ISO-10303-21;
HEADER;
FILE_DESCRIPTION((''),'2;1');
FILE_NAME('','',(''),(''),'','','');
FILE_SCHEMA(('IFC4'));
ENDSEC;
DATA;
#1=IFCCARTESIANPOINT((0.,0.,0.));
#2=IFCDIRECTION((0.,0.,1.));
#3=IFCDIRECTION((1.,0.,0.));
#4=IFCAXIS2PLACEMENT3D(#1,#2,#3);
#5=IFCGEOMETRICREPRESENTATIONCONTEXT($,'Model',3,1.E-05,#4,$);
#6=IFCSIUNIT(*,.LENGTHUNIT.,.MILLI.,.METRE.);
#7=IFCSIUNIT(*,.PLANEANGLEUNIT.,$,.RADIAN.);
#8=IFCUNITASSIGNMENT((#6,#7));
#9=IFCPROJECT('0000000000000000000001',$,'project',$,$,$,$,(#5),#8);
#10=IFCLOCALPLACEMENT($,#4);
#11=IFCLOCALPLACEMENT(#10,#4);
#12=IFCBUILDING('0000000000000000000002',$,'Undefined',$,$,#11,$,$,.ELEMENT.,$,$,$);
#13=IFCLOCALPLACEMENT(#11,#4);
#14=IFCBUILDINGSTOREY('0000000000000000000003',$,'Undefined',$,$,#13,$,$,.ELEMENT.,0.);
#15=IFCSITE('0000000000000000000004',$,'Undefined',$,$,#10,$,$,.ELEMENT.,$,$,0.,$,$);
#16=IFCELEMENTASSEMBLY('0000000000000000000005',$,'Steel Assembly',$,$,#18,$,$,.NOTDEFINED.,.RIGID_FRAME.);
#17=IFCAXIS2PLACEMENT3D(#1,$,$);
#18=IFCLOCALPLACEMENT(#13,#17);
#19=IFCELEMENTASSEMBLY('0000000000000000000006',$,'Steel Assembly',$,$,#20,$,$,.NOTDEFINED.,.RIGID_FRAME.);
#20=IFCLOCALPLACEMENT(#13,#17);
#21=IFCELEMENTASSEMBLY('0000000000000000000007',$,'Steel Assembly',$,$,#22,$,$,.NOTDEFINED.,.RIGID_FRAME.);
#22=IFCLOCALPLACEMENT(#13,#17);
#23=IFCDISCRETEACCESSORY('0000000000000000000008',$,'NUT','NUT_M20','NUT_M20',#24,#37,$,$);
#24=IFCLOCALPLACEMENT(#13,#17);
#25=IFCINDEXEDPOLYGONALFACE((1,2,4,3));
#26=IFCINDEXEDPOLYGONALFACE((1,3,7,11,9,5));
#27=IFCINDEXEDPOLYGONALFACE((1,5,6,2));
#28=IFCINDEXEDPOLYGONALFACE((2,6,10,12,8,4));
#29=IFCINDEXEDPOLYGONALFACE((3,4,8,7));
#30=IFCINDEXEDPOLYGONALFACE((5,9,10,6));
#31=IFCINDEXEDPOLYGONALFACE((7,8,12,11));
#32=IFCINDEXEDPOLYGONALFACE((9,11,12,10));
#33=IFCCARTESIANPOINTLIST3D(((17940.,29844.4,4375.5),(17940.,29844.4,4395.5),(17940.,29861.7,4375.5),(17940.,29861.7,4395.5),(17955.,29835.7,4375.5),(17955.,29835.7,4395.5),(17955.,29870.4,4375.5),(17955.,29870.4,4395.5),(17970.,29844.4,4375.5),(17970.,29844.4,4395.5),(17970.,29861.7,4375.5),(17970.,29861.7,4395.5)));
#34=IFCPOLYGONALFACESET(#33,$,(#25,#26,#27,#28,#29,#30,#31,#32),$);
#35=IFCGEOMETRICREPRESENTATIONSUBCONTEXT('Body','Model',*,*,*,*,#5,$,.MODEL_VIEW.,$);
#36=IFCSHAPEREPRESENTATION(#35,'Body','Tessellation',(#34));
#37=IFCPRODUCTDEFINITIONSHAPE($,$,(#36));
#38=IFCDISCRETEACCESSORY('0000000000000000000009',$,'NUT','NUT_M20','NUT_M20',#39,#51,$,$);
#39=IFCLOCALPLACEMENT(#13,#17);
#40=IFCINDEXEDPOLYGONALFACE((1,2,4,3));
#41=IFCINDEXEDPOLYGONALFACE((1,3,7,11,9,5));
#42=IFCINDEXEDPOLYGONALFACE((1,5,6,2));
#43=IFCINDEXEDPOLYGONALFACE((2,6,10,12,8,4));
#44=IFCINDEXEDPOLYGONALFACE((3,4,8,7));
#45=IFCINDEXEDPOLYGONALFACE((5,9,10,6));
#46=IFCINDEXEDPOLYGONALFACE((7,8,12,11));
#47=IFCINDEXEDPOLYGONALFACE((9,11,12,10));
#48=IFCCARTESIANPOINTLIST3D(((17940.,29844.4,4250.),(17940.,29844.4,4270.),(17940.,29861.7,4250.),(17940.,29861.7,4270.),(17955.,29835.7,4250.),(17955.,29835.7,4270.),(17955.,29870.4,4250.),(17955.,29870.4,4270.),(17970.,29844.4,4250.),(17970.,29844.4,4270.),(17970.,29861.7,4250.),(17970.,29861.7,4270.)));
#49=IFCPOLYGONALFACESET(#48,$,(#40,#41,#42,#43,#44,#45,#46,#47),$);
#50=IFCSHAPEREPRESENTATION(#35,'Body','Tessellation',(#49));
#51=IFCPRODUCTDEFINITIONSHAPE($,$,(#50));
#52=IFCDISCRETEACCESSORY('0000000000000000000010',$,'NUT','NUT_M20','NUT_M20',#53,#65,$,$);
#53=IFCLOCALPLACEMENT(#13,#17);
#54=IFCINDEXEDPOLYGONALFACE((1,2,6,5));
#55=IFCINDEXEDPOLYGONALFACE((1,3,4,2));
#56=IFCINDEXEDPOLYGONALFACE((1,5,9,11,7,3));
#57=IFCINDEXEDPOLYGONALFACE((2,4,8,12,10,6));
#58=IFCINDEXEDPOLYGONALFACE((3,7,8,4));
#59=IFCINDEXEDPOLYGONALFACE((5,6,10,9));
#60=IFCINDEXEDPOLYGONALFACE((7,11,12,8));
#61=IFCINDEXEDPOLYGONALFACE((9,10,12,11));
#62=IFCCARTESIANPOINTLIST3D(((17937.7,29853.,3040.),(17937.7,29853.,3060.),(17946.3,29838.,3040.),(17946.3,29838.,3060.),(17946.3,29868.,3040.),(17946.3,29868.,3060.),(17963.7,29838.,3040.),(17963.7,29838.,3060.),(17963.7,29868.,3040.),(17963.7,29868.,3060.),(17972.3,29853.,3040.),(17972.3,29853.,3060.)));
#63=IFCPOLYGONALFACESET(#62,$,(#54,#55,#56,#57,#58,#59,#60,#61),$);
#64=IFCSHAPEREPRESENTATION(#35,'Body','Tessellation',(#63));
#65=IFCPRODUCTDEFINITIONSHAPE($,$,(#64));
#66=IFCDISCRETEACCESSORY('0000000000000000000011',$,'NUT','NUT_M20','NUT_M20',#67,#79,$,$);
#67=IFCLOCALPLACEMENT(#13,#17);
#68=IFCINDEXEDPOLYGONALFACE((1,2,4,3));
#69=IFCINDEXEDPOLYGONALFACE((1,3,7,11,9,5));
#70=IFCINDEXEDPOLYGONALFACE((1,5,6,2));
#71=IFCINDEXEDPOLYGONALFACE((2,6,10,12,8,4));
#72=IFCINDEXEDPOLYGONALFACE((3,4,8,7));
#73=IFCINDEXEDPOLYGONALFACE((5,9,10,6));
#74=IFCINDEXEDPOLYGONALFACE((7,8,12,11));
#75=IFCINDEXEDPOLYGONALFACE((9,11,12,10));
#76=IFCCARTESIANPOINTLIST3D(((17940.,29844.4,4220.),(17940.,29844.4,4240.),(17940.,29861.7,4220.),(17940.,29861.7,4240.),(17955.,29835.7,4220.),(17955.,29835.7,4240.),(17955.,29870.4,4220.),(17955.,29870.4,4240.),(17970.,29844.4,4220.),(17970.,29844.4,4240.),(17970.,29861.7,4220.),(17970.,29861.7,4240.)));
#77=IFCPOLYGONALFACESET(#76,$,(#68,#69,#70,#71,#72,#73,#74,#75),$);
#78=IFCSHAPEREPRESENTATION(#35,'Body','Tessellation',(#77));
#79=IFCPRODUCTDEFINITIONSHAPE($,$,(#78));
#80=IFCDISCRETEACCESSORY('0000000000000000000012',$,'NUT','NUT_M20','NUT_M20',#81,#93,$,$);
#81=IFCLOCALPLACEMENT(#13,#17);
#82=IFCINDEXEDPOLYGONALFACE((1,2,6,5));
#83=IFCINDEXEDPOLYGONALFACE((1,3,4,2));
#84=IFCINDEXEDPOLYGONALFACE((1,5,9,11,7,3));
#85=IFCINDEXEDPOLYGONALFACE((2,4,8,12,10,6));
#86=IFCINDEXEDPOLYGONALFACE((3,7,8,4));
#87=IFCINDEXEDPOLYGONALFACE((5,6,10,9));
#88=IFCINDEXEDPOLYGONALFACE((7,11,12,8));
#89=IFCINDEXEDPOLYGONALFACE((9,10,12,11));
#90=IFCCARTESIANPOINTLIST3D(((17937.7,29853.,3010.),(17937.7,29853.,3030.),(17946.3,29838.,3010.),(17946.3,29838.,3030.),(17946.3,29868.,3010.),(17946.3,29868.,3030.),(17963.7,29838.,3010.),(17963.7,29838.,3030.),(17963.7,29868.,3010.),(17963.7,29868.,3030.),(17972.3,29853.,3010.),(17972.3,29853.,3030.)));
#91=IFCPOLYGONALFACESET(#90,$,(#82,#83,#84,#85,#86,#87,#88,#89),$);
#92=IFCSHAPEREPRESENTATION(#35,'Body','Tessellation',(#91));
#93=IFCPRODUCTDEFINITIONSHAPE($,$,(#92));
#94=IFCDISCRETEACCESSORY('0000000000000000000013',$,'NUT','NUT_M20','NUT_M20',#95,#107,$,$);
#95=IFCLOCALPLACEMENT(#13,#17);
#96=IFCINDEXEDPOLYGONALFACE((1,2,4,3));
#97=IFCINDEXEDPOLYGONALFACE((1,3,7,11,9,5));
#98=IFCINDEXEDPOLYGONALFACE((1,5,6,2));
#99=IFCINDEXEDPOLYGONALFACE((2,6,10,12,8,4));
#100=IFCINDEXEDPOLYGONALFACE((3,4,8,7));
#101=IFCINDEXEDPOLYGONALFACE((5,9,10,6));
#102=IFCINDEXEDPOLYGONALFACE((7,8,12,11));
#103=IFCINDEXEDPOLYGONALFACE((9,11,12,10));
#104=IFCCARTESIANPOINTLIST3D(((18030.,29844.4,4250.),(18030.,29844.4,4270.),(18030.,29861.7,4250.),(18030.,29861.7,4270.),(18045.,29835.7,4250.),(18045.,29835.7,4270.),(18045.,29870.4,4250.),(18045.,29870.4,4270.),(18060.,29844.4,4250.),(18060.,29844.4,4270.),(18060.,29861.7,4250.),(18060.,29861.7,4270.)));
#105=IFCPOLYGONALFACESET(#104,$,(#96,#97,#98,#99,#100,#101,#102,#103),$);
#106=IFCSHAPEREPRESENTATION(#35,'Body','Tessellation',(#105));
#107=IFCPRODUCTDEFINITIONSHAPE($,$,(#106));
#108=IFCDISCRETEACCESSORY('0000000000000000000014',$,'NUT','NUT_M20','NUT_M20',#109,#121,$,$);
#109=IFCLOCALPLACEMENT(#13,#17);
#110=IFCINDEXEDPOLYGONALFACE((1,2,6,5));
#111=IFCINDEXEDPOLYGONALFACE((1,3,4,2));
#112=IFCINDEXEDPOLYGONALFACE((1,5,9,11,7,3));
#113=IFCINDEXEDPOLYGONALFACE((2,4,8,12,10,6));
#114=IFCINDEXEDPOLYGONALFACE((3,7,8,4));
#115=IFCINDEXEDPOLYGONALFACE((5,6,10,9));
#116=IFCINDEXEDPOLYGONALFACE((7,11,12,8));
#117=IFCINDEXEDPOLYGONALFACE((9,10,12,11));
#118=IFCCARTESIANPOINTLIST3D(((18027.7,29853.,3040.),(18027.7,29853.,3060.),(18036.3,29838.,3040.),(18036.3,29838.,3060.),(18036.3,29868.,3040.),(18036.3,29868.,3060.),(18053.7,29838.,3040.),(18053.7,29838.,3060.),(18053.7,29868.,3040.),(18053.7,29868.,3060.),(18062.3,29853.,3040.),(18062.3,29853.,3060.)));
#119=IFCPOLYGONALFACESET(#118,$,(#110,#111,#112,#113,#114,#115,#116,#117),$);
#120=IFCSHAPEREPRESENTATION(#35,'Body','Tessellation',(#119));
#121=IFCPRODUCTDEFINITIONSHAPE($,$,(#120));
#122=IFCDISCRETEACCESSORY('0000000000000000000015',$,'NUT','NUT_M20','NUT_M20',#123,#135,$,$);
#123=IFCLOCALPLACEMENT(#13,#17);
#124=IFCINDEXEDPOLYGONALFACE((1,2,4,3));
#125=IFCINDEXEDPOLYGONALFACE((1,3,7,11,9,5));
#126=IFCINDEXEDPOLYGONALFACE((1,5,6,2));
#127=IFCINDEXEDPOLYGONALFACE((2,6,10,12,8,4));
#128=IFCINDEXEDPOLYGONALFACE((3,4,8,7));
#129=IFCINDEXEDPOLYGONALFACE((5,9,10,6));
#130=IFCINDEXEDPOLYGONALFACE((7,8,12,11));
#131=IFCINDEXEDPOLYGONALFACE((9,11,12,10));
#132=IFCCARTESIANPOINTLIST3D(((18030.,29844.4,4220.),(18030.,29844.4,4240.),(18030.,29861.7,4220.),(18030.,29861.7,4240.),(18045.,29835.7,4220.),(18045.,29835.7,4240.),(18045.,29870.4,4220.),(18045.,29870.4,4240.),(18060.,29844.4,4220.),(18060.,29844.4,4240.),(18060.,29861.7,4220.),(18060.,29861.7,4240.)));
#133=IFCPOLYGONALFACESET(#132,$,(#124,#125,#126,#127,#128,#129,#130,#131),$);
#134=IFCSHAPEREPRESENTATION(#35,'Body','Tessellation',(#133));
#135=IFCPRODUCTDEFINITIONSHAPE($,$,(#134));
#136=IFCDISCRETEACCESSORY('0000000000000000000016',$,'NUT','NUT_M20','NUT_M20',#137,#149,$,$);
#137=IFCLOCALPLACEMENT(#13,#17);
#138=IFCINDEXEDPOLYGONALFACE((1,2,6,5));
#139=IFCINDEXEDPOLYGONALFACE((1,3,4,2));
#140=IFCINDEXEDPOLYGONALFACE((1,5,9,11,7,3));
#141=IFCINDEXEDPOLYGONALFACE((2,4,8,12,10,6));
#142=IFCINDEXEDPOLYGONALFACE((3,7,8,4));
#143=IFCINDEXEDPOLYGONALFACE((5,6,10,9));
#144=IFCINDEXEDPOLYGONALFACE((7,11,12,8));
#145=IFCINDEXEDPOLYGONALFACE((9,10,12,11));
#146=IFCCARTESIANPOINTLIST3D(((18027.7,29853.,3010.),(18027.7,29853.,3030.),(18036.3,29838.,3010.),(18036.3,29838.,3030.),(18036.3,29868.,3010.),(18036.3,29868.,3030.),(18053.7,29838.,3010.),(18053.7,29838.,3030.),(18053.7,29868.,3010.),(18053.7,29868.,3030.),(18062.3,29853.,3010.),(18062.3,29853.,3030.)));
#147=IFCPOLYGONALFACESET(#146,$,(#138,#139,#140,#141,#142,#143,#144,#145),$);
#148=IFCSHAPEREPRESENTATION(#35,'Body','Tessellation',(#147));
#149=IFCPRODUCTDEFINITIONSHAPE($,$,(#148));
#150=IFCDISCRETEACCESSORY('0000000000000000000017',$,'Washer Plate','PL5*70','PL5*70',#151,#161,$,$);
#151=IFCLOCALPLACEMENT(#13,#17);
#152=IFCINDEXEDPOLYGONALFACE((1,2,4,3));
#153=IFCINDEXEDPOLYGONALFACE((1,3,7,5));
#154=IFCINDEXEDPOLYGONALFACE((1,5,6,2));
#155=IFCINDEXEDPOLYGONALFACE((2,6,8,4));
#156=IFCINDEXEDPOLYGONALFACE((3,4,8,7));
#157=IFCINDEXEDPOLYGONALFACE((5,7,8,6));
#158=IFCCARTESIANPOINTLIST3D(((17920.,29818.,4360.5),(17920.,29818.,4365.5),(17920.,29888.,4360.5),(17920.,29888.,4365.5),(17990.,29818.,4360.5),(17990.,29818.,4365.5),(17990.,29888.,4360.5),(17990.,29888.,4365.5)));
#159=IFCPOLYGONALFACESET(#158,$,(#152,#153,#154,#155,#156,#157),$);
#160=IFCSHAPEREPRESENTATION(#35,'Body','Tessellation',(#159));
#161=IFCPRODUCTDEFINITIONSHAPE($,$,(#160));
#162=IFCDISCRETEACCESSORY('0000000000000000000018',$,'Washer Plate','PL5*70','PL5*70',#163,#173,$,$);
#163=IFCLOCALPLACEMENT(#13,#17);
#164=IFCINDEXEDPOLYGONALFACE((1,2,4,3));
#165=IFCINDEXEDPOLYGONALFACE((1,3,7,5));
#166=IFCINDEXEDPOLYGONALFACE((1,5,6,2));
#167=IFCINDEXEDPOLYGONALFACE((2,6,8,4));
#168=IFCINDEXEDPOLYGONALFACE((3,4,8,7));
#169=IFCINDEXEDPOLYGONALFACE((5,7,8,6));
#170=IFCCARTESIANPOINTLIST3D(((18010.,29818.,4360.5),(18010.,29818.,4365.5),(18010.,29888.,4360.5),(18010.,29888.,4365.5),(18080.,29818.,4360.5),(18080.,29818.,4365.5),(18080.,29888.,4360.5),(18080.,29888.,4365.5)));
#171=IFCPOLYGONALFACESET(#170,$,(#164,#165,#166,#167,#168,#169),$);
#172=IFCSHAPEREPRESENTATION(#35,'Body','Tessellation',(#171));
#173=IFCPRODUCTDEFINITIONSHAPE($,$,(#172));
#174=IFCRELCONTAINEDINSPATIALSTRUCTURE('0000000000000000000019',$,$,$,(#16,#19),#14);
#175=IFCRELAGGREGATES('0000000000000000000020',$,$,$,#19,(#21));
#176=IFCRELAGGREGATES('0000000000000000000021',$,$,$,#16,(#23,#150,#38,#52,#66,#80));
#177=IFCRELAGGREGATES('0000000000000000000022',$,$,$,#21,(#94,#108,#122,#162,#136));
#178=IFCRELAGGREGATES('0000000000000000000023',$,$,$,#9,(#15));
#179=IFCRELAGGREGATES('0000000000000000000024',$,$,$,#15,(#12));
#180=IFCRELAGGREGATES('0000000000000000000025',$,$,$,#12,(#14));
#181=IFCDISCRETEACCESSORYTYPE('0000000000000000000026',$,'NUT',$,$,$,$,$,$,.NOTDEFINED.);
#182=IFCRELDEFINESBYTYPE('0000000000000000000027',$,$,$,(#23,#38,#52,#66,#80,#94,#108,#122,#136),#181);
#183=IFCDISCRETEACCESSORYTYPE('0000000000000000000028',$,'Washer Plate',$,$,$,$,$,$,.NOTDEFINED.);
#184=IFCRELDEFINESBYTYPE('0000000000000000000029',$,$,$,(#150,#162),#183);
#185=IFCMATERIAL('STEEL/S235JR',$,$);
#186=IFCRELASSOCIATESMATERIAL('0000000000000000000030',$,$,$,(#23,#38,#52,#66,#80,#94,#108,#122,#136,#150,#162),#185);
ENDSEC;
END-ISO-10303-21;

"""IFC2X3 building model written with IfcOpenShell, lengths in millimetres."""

from ifc_helpers import new_model, si_unit, frame, origin_with_axes, place, context, subcontext, project, spatial, polyline, outline, extrude, material, type_object, element, aggregate, save


model = new_model("IFC2X3")

# Units and contexts
model_context = context("Model", 3, precision=1e-05, world=origin_with_axes())
body_context = subcontext(model_context, "Body", "Model", "MODEL_VIEW")
ifc_project = project(units=[si_unit("LENGTHUNIT", "METRE", prefix="MILLI"), si_unit("PLANEANGLEUNIT", "RADIAN")], contexts=[model_context])

# Site, building, storey
site_placement = place(None, origin_with_axes())
site = spatial("IfcSite", under=ifc_project, at=site_placement, Name="Undefined", CompositionType="ELEMENT", RefElevation=0.0)
building_placement = place(site_placement, origin_with_axes())
building = spatial("IfcBuilding", under=site, at=building_placement, Name="Undefined", CompositionType="ELEMENT")
storey_placement = place(building_placement, origin_with_axes())
storey = spatial("IfcBuildingStorey", under=building, at=storey_placement, Name="Undefined", CompositionType="ELEMENT", Elevation=0.0)

# Element assembly
assembly_1_placement = place(storey_placement, origin_with_axes())
assembly_1 = element("IfcElementAssembly", 1, at=assembly_1_placement, inside=storey, Name="Steel Assembly", AssemblyPlace="NOTDEFINED", PredefinedType="RIGID_FRAME")

# Element assemblies
assembly_2_placement = place(storey_placement, origin_with_axes())
assembly_2 = element("IfcElementAssembly", 2, at=assembly_2_placement, inside=storey, Name="Steel Assembly", AssemblyPlace="NOTDEFINED", PredefinedType="RIGID_FRAME")
assembly_3_placement = place(assembly_2_placement, origin_with_axes())
assembly_3 = element("IfcElementAssembly", 3, at=assembly_3_placement, Name="Steel Assembly", AssemblyPlace="NOTDEFINED", PredefinedType="RIGID_FRAME")

# Shared definitions
ifc_material_1 = material(Name="STEEL/S235JR")

aggregate(assembly_2, [assembly_3])

# Discrete accessories
discrete_accessory_type_1 = type_object("IfcDiscreteAccessoryType", Name="NUT")
discrete_accessory_1_placement = place(assembly_1_placement, frame((17955.0, 29853.0, 4395.5), z_axis=(-1.0, 0.0, 0.0), x_axis=(0.0, 0.0, -1.0)))
discrete_accessory_1 = element("IfcDiscreteAccessory", 4, at=discrete_accessory_1_placement, type_object=discrete_accessory_type_1, material=ifc_material_1, Name="NUT", Description="NUT_M20", ObjectType="NUT_M20", context=body_context, shape_type="SweptSolid", body=[
    extrude(outline(polyline([(8.7, 15.0), (17.3, 0.0), (8.7, -15.0), (-8.7, -15.0), (-17.3, 0.0), (-8.7, 15.0), (8.7, 15.0)])), frame((20.0, 0.0, 0.0), z_axis=(-1.0, 0.0, 0.0), x_axis=(0.0, -1.0, 0.0)), (0.0, 0.0, 1.0), 20.0),
])
discrete_accessory_2_placement = place(assembly_1_placement, frame((17955.0, 29853.0, 4270.0), z_axis=(-1.0, 0.0, 0.0), x_axis=(0.0, 0.0, -1.0)))
discrete_accessory_2 = element("IfcDiscreteAccessory", 5, at=discrete_accessory_2_placement, type_object=discrete_accessory_type_1, material=ifc_material_1, Name="NUT", Description="NUT_M20", ObjectType="NUT_M20", context=body_context, shape_type="SweptSolid", body=[
    extrude(outline(polyline([(8.7, 15.0), (17.3, 0.0), (8.7, -15.0), (-8.7, -15.0), (-17.3, 0.0), (-8.7, 15.0), (8.7, 15.0)])), frame((20.0, 0.0, 0.0), z_axis=(-1.0, 0.0, 0.0), x_axis=(0.0, -1.0, 0.0)), (0.0, 0.0, 1.0), 20.0),
])
discrete_accessory_3_placement = place(assembly_1_placement, frame((17955.0, 29853.0, 3060.0), z_axis=(0.0, -1.0, 0.0), x_axis=(0.0, 0.0, -1.0)))
discrete_accessory_3 = element("IfcDiscreteAccessory", 6, at=discrete_accessory_3_placement, type_object=discrete_accessory_type_1, material=ifc_material_1, Name="NUT", Description="NUT_M20", ObjectType="NUT_M20", context=body_context, shape_type="SweptSolid", body=[
    extrude(outline(polyline([(8.7, 15.0), (17.3, 0.0), (8.7, -15.0), (-8.7, -15.0), (-17.3, 0.0), (-8.7, 15.0), (8.7, 15.0)])), frame((20.0, 0.0, 0.0), z_axis=(-1.0, 0.0, 0.0), x_axis=(0.0, -1.0, 0.0)), (0.0, 0.0, 1.0), 20.0),
])
discrete_accessory_4_placement = place(assembly_1_placement, frame((17955.0, 29853.0, 4240.0), z_axis=(-1.0, 0.0, 0.0), x_axis=(0.0, 0.0, -1.0)))
discrete_accessory_4 = element("IfcDiscreteAccessory", 7, at=discrete_accessory_4_placement, type_object=discrete_accessory_type_1, material=ifc_material_1, Name="NUT", Description="NUT_M20", ObjectType="NUT_M20", context=body_context, shape_type="SweptSolid", body=[
    extrude(outline(polyline([(8.7, 15.0), (17.3, 0.0), (8.7, -15.0), (-8.7, -15.0), (-17.3, 0.0), (-8.7, 15.0), (8.7, 15.0)])), frame((20.0, 0.0, 0.0), z_axis=(-1.0, 0.0, 0.0), x_axis=(0.0, -1.0, 0.0)), (0.0, 0.0, 1.0), 20.0),
])
discrete_accessory_5_placement = place(assembly_1_placement, frame((17955.0, 29853.0, 3030.0), z_axis=(0.0, -1.0, 0.0), x_axis=(0.0, 0.0, -1.0)))
discrete_accessory_5 = element("IfcDiscreteAccessory", 8, at=discrete_accessory_5_placement, type_object=discrete_accessory_type_1, material=ifc_material_1, Name="NUT", Description="NUT_M20", ObjectType="NUT_M20", context=body_context, shape_type="SweptSolid", body=[
    extrude(outline(polyline([(8.7, 15.0), (17.3, 0.0), (8.7, -15.0), (-8.7, -15.0), (-17.3, 0.0), (-8.7, 15.0), (8.7, 15.0)])), frame((20.0, 0.0, 0.0), z_axis=(-1.0, 0.0, 0.0), x_axis=(0.0, -1.0, 0.0)), (0.0, 0.0, 1.0), 20.0),
])
discrete_accessory_6_placement = place(assembly_3_placement, frame((18045.0, 29853.0, 4270.0), z_axis=(-1.0, 0.0, 0.0), x_axis=(0.0, 0.0, -1.0)))
discrete_accessory_6 = element("IfcDiscreteAccessory", 9, at=discrete_accessory_6_placement, type_object=discrete_accessory_type_1, material=ifc_material_1, Name="NUT", Description="NUT_M20", ObjectType="NUT_M20", context=body_context, shape_type="SweptSolid", body=[
    extrude(outline(polyline([(8.7, 15.0), (17.3, 0.0), (8.7, -15.0), (-8.7, -15.0), (-17.3, 0.0), (-8.7, 15.0), (8.7, 15.0)])), frame((20.0, 0.0, 0.0), z_axis=(-1.0, 0.0, 0.0), x_axis=(0.0, -1.0, 0.0)), (0.0, 0.0, 1.0), 20.0),
])
discrete_accessory_7_placement = place(assembly_3_placement, frame((18045.0, 29853.0, 3060.0), z_axis=(0.0, -1.0, 0.0), x_axis=(0.0, 0.0, -1.0)))
discrete_accessory_7 = element("IfcDiscreteAccessory", 10, at=discrete_accessory_7_placement, type_object=discrete_accessory_type_1, material=ifc_material_1, Name="NUT", Description="NUT_M20", ObjectType="NUT_M20", context=body_context, shape_type="SweptSolid", body=[
    extrude(outline(polyline([(8.7, 15.0), (17.3, 0.0), (8.7, -15.0), (-8.7, -15.0), (-17.3, 0.0), (-8.7, 15.0), (8.7, 15.0)])), frame((20.0, 0.0, 0.0), z_axis=(-1.0, 0.0, 0.0), x_axis=(0.0, -1.0, 0.0)), (0.0, 0.0, 1.0), 20.0),
])
discrete_accessory_8_placement = place(assembly_3_placement, frame((18045.0, 29853.0, 4240.0), z_axis=(-1.0, 0.0, 0.0), x_axis=(0.0, 0.0, -1.0)))
discrete_accessory_8 = element("IfcDiscreteAccessory", 11, at=discrete_accessory_8_placement, type_object=discrete_accessory_type_1, material=ifc_material_1, Name="NUT", Description="NUT_M20", ObjectType="NUT_M20", context=body_context, shape_type="SweptSolid", body=[
    extrude(outline(polyline([(8.7, 15.0), (17.3, 0.0), (8.7, -15.0), (-8.7, -15.0), (-17.3, 0.0), (-8.7, 15.0), (8.7, 15.0)])), frame((20.0, 0.0, 0.0), z_axis=(-1.0, 0.0, 0.0), x_axis=(0.0, -1.0, 0.0)), (0.0, 0.0, 1.0), 20.0),
])
discrete_accessory_9_placement = place(assembly_3_placement, frame((18045.0, 29853.0, 3030.0), z_axis=(0.0, -1.0, 0.0), x_axis=(0.0, 0.0, -1.0)))
discrete_accessory_9 = element("IfcDiscreteAccessory", 12, at=discrete_accessory_9_placement, type_object=discrete_accessory_type_1, material=ifc_material_1, Name="NUT", Description="NUT_M20", ObjectType="NUT_M20", context=body_context, shape_type="SweptSolid", body=[
    extrude(outline(polyline([(8.7, 15.0), (17.3, 0.0), (8.7, -15.0), (-8.7, -15.0), (-17.3, 0.0), (-8.7, 15.0), (8.7, 15.0)])), frame((20.0, 0.0, 0.0), z_axis=(-1.0, 0.0, 0.0), x_axis=(0.0, -1.0, 0.0)), (0.0, 0.0, 1.0), 20.0),
])
discrete_accessory_type_2 = type_object("IfcDiscreteAccessoryType", Name="Washer Plate")
discrete_accessory_10_placement = place(assembly_1_placement, frame((17990.0, 29818.0, 4363.0), z_axis=(0.0, 0.0, 1.0), x_axis=(0.0, 1.0, 0.0)))
discrete_accessory_10 = element("IfcDiscreteAccessory", 13, at=discrete_accessory_10_placement, type_object=discrete_accessory_type_2, material=ifc_material_1, Name="Washer Plate", Description="PL5*70", ObjectType="PL5*70", context=body_context, shape_type="SweptSolid", body=[
    extrude(outline(polyline([(0.0, 0.0), (70.0, 0.0), (70.0, 70.0), (0.0, 70.0), (0.0, 0.0)])), frame((0.0, 0.0, -2.5), z_axis=(0.0, 0.0, 1.0), x_axis=(1.0, 0.0, 0.0)), (0.0, 0.0, 1.0), 5.0),
])
discrete_accessory_11_placement = place(assembly_3_placement, frame((18080.0, 29818.0, 4363.0), z_axis=(0.0, 0.0, 1.0), x_axis=(0.0, 1.0, 0.0)))
discrete_accessory_11 = element("IfcDiscreteAccessory", 14, at=discrete_accessory_11_placement, type_object=discrete_accessory_type_2, material=ifc_material_1, Name="Washer Plate", Description="PL5*70", ObjectType="PL5*70", context=body_context, shape_type="SweptSolid", body=[
    extrude(outline(polyline([(0.0, 0.0), (70.0, 0.0), (70.0, 70.0), (0.0, 70.0), (0.0, 0.0)])), frame((0.0, 0.0, -2.5), z_axis=(0.0, 0.0, 1.0), x_axis=(1.0, 0.0, 0.0)), (0.0, 0.0, 1.0), 5.0),
])
aggregate(assembly_1, [discrete_accessory_1, discrete_accessory_10, discrete_accessory_2, discrete_accessory_3, discrete_accessory_4, discrete_accessory_5])
aggregate(assembly_3, [discrete_accessory_6, discrete_accessory_7, discrete_accessory_8, discrete_accessory_11, discrete_accessory_9])

save(model, "model.ifc")
